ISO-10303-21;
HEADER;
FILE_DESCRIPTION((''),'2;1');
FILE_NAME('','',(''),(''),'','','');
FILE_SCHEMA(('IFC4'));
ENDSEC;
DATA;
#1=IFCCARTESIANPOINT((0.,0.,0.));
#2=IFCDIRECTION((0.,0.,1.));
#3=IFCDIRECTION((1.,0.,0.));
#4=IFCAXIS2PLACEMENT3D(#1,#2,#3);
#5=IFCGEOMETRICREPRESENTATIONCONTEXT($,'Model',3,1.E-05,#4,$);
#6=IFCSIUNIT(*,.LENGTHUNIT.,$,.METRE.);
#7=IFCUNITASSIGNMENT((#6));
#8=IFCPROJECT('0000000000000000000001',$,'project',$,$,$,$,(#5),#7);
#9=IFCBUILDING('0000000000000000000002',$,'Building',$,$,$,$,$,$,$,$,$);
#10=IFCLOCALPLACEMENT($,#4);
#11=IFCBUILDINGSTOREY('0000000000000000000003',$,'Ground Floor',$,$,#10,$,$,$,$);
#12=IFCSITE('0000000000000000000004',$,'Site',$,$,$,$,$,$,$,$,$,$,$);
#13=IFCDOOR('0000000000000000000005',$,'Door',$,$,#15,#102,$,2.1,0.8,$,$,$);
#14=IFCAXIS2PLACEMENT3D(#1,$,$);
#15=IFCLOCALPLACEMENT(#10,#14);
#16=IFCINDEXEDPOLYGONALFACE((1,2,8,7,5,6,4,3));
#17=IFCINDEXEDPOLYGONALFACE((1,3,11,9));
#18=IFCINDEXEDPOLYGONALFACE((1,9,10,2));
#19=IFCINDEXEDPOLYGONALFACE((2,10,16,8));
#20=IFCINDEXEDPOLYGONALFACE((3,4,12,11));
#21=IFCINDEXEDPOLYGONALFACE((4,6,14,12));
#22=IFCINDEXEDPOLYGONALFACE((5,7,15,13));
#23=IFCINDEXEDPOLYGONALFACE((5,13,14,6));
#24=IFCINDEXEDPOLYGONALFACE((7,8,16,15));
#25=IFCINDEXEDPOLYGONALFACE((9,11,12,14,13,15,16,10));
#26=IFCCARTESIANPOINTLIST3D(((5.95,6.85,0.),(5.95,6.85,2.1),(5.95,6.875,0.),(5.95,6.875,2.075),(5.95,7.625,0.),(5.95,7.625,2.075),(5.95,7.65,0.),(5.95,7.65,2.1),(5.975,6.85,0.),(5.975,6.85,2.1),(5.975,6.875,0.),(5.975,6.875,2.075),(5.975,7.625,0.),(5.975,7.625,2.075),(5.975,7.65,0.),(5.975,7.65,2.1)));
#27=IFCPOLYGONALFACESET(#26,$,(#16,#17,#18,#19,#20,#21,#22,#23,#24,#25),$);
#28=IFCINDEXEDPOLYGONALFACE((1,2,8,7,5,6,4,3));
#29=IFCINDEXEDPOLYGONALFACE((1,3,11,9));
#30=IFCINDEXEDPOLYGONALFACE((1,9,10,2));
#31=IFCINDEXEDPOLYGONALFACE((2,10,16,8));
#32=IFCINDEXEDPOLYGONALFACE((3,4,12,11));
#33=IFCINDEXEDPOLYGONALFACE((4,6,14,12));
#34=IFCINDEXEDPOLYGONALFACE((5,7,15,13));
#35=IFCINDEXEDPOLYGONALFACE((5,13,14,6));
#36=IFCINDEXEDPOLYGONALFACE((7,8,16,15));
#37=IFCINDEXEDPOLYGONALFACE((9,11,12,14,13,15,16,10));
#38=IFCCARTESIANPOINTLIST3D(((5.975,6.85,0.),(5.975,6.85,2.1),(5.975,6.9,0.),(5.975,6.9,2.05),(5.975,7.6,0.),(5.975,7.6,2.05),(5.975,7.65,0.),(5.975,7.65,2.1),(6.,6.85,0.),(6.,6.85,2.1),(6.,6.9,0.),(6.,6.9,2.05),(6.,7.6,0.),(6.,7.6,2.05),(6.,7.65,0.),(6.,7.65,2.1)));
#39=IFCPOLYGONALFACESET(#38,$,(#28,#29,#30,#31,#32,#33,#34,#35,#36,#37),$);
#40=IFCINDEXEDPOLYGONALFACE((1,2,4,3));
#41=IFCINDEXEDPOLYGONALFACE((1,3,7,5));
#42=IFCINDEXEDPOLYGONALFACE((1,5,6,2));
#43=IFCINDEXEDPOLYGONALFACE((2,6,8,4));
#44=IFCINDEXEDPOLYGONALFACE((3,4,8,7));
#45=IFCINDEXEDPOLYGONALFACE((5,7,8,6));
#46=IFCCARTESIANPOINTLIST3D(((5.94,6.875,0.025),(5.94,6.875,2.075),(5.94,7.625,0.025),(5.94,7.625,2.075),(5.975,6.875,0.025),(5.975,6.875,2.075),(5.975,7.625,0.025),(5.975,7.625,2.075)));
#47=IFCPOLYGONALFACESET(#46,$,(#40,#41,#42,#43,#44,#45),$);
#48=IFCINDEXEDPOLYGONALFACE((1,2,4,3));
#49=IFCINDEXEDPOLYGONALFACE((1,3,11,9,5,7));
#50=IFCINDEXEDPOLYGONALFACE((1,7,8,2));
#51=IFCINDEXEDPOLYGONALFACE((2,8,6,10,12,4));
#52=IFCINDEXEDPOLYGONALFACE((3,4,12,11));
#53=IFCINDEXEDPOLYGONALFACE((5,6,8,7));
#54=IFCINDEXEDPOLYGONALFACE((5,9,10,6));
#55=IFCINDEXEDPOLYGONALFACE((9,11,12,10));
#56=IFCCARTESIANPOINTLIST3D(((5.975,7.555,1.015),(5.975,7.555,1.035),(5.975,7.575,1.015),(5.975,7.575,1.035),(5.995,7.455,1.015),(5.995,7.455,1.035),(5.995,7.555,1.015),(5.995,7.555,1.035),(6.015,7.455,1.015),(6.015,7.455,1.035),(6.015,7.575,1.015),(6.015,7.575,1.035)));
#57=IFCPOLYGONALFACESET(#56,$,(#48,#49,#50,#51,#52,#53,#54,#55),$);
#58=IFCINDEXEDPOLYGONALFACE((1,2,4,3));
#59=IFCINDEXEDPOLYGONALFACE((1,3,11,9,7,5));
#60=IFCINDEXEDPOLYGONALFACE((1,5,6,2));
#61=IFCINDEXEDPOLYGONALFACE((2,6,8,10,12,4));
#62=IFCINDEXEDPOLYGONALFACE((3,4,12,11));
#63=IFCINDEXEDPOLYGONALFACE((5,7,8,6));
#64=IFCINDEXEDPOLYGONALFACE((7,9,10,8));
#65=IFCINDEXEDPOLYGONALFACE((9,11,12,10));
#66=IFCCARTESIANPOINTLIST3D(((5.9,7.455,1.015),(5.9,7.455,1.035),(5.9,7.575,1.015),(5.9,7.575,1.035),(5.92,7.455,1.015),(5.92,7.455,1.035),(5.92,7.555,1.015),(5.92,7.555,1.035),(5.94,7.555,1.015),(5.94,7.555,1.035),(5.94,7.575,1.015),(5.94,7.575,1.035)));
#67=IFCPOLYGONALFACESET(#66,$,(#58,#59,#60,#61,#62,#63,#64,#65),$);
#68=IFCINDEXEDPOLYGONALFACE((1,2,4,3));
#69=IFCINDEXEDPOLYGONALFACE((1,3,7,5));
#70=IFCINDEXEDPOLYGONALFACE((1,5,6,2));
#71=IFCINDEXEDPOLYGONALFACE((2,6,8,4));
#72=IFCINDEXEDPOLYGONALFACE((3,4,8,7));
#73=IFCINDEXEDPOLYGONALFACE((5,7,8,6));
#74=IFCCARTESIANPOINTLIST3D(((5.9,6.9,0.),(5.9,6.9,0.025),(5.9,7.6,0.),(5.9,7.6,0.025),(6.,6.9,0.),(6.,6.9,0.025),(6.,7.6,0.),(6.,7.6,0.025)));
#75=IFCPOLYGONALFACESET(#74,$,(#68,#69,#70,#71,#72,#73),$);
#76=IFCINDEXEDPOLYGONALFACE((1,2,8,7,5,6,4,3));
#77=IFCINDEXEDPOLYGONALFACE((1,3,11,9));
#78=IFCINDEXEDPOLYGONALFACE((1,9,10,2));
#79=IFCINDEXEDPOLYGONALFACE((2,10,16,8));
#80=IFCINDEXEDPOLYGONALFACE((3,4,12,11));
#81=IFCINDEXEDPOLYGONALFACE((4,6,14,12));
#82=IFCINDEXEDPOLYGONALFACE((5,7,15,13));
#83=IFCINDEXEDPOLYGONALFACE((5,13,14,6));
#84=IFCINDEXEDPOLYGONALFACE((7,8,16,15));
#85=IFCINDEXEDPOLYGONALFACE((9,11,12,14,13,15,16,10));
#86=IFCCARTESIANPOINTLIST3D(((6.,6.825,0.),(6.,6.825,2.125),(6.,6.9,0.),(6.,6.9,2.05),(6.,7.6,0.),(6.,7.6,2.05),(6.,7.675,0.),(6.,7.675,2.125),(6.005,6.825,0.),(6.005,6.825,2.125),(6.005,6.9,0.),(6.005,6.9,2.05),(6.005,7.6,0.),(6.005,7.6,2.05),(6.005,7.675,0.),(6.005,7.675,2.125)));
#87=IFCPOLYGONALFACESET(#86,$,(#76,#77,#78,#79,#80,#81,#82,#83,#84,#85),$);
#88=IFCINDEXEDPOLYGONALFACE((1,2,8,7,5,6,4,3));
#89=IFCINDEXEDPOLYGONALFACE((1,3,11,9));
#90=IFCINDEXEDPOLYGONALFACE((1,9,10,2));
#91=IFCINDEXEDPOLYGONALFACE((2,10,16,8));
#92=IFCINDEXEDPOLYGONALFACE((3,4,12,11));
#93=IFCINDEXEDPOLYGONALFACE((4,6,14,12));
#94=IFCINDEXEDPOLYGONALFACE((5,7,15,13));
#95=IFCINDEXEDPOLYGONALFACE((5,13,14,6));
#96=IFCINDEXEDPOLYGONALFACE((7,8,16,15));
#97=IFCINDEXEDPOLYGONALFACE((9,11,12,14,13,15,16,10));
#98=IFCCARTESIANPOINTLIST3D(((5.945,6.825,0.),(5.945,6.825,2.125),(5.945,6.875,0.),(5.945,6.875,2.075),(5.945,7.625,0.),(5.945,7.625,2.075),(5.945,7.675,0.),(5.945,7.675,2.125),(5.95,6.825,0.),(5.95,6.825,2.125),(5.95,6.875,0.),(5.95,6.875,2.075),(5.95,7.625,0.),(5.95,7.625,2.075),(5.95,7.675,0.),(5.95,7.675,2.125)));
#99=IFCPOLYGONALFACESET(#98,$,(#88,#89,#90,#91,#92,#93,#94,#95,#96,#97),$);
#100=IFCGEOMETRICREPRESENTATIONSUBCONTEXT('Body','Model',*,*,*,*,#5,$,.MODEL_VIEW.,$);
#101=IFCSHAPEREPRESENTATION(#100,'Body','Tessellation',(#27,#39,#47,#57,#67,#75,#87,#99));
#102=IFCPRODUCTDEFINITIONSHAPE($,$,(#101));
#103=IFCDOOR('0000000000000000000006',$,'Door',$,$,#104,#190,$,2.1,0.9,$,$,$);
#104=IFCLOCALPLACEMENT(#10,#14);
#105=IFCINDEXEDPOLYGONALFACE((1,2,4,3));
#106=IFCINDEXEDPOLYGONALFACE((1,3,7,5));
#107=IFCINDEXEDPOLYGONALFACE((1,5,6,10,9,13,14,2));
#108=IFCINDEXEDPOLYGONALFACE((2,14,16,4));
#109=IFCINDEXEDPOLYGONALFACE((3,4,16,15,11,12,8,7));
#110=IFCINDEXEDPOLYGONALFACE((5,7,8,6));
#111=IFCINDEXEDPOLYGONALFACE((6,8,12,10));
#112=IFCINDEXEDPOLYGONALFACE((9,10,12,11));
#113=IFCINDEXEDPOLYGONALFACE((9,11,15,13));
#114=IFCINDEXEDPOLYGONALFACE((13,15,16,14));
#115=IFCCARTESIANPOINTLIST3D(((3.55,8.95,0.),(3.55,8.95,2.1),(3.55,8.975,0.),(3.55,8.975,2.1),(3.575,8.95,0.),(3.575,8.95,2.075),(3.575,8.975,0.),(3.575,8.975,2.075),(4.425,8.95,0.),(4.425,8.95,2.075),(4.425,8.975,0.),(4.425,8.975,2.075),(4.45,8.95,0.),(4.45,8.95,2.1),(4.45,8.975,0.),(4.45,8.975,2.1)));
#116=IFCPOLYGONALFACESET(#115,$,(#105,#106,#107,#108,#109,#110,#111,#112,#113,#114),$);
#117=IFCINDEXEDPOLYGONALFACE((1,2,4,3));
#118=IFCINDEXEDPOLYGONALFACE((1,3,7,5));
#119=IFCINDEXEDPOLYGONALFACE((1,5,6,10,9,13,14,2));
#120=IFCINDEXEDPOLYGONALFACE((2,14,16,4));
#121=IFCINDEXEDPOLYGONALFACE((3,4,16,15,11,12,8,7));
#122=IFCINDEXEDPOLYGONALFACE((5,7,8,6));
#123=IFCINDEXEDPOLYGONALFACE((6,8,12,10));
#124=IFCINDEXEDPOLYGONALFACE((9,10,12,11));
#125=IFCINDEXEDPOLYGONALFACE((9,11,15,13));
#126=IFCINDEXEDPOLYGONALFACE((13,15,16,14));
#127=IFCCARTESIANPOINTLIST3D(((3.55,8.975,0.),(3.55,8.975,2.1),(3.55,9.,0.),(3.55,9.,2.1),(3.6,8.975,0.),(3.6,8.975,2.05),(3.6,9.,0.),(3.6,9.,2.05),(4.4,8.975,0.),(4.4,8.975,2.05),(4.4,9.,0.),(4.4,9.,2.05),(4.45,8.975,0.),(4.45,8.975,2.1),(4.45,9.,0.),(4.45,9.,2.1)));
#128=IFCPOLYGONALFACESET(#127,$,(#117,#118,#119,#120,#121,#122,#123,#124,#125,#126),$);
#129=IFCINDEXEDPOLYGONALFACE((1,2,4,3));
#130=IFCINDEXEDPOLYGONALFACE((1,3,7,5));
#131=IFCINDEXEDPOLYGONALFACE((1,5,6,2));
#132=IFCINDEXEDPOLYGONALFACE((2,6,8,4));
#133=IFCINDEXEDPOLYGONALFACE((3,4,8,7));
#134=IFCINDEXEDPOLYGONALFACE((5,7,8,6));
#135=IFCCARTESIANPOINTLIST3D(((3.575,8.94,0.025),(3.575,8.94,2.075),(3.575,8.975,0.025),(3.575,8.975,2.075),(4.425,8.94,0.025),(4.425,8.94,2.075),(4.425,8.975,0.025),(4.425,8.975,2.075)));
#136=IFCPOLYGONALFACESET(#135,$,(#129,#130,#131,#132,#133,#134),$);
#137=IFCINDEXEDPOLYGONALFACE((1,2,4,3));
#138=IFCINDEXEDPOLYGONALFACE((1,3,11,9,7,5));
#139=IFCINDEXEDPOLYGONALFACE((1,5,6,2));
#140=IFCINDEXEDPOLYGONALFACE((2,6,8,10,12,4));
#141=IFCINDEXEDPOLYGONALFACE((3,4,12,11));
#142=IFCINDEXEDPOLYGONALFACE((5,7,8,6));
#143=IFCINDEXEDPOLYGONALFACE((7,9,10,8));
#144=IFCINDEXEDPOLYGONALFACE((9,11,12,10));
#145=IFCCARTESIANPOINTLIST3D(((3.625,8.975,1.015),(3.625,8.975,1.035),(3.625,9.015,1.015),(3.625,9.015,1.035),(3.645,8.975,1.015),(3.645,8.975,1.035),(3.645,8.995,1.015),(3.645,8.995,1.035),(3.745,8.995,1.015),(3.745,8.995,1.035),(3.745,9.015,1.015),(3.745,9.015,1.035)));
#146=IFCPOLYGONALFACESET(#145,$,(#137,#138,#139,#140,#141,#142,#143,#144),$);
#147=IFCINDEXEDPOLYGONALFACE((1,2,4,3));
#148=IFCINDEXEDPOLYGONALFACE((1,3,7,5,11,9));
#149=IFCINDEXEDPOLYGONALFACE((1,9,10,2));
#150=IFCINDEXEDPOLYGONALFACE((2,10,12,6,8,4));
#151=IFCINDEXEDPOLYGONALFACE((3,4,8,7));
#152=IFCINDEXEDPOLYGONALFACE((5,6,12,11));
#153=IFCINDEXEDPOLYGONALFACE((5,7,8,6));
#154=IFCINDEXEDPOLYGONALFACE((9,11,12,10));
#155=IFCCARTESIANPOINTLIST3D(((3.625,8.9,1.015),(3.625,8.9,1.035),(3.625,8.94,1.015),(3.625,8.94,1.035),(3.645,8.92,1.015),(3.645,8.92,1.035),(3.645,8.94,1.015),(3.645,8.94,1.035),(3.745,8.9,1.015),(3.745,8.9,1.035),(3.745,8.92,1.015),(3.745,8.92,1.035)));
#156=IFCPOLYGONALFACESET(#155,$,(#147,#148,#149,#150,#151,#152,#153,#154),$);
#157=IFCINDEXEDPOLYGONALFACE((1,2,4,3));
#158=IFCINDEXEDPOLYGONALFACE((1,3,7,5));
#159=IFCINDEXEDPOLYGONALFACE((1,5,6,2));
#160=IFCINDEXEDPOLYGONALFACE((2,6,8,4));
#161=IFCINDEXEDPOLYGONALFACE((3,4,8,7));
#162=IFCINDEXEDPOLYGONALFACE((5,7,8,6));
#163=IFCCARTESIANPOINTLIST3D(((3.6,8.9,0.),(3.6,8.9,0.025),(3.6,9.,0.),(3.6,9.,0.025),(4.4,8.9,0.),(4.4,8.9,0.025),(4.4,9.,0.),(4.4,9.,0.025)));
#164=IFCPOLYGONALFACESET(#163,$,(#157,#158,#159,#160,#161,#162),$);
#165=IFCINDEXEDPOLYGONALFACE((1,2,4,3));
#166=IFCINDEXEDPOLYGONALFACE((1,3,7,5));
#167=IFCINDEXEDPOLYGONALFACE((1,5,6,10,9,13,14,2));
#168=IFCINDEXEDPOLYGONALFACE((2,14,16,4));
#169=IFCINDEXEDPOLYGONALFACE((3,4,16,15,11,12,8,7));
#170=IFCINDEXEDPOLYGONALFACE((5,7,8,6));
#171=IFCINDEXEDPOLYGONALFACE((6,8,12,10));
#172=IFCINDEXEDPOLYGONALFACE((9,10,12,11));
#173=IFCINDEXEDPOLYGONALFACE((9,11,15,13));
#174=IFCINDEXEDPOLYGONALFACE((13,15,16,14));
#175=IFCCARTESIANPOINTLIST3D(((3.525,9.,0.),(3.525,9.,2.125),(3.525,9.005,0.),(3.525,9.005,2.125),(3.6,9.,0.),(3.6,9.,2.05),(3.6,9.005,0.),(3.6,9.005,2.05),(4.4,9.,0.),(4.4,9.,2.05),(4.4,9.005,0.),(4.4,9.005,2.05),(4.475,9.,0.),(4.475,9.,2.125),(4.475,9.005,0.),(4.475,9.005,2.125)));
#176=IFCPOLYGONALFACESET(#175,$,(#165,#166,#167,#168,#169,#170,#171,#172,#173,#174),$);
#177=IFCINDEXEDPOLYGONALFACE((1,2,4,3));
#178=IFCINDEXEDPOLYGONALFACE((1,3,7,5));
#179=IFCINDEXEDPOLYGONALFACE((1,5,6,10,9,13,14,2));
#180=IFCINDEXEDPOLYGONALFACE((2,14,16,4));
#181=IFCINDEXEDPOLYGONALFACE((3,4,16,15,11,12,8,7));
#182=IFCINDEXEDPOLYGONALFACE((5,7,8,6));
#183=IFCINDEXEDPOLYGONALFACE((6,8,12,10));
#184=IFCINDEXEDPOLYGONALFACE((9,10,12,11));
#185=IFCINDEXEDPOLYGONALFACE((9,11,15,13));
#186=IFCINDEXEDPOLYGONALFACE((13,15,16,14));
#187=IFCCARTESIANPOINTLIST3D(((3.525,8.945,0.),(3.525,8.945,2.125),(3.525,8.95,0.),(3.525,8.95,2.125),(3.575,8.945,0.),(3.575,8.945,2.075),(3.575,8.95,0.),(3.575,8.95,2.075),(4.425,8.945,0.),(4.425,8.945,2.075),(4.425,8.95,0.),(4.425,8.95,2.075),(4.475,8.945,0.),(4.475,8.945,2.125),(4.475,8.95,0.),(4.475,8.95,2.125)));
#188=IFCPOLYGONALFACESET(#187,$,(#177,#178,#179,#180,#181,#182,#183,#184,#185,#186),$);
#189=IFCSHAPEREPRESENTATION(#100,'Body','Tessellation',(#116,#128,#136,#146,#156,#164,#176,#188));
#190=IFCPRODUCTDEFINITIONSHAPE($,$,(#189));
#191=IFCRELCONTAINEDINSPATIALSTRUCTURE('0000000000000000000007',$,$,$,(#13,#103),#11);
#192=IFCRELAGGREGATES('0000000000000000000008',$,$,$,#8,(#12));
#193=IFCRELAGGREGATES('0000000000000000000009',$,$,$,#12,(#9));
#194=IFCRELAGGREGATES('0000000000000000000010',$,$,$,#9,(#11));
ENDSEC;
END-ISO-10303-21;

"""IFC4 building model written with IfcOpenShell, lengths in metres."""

from ifc_helpers import new_model, si_unit, frame, origin_with_axes, place, context, subcontext, project, spatial, line, indexed_curve, outline, extrude, element, save


model = new_model("IFC4")

# Units and contexts
model_context = context("Model", 3, precision=1e-05, world=origin_with_axes())
body_context = subcontext(model_context, "Body", "Model", "MODEL_VIEW")
ifc_project = project(units=[si_unit("LENGTHUNIT", "METRE")], contexts=[model_context])

# Site, building, storey
site = spatial("IfcSite", under=ifc_project, Name="Site")
building = spatial("IfcBuilding", under=site, Name="Building")
storey_placement = place(None, origin_with_axes())
storey = spatial("IfcBuildingStorey", under=building, at=storey_placement, Name="Ground Floor")

# Doors
door_1_placement = place(storey_placement, frame((6.0, 6.85, 0.0), z_axis=(0.0, 0.0, 1.0), x_axis=(0.0, 1.0, 0.0)))
element("IfcDoor", 1, at=door_1_placement, inside=storey, Name="Door", OverallHeight=2.1, OverallWidth=0.8, context=body_context, shape_type="SweptSolid", body=[
    extrude(outline(indexed_curve([(0.0, 0.0), (0.0, 2.1), (0.8, 2.1), (0.8, 0.0), (0.775, 0.0), (0.775, 2.075), (0.025, 2.075), (0.025, 0.0)], segments=[line(1, 2, 3, 4, 5, 6, 7, 8, 1)])), frame((0.0, 0.025, 0.0), z_axis=(0.0, -1.0, 0.0), x_axis=(1.0, 0.0, 0.0)), (0.0, 0.0, -1.0), 0.025),
    extrude(outline(indexed_curve([(0.0, 0.0), (0.0, 2.1), (0.8, 2.1), (0.8, 0.0), (0.75, 0.0), (0.75, 2.05), (0.05, 2.05), (0.05, 0.0)], segments=[line(1, 2, 3, 4, 5, 6, 7, 8, 1)])), frame((0.0, 0.0, 0.0), z_axis=(0.0, -1.0, 0.0), x_axis=(1.0, 0.0, 0.0)), (0.0, 0.0, -1.0), 0.025),
    extrude(outline(indexed_curve([(0.0, 0.0), (0.75, 0.0), (0.75, 0.035), (0.0, 0.035)], segments=[line(1, 2, 3, 4, 1)])), frame((0.025, 0.025, 0.025), z_axis=(0.0, 0.0, 1.0), x_axis=(1.0, 0.0, 0.0)), (0.0, 0.0, 1.0), 2.05),
    extrude(outline(indexed_curve([(0.0, 0.0), (0.0, -0.04), (-0.12, -0.04), (-0.12, -0.02), (-0.02, -0.02), (-0.02, 0.0)], segments=[line(1, 2, 3, 4, 5, 6, 1)])), frame((0.725, 0.025, 1.015), z_axis=(0.0, 0.0, 1.0), x_axis=(1.0, 0.0, 0.0)), (0.0, 0.0, 1.0), 0.02),
    extrude(outline(indexed_curve([(0.0, 0.0), (0.0, 0.04), (-0.12, 0.04), (-0.12, 0.02), (-0.02, 0.02), (-0.02, 0.0)], segments=[line(1, 2, 3, 4, 5, 6, 1)])), frame((0.725, 0.06, 1.015), z_axis=(0.0, 0.0, 1.0), x_axis=(1.0, 0.0, 0.0)), (0.0, 0.0, 1.0), 0.02),
    extrude(outline(indexed_curve([(0.0, 0.0), (0.7, 0.0), (0.7, 0.1), (0.0, 0.1)], segments=[line(1, 2, 3, 4, 1)])), frame((0.05, 0.0, 0.0), z_axis=(0.0, 0.0, 1.0), x_axis=(1.0, 0.0, 0.0)), (0.0, 0.0, 1.0), 0.025),
    extrude(outline(indexed_curve([(0.0, 0.0), (0.0, 2.125), (0.85, 2.125), (0.85, 0.0), (0.775, 0.0), (0.775, 2.05), (0.075, 2.05), (0.075, 0.0)], segments=[line(1, 2, 3, 4, 5, 6, 7, 8, 1)])), frame((-0.025, -0.005, 0.0), z_axis=(0.0, -1.0, 0.0), x_axis=(1.0, 0.0, 0.0)), (0.0, 0.0, -1.0), 0.005),
    extrude(outline(indexed_curve([(0.0, 0.0), (0.0, 2.125), (0.85, 2.125), (0.85, 0.0), (0.8, 0.0), (0.8, 2.075), (0.05, 2.075), (0.05, 0.0)], segments=[line(1, 2, 3, 4, 5, 6, 7, 8, 1)])), frame((-0.025, 0.05, 0.0), z_axis=(0.0, -1.0, 0.0), x_axis=(1.0, 0.0, 0.0)), (0.0, 0.0, -1.0), 0.005),
])
door_2_placement = place(storey_placement, frame((4.45, 9.0, 0.0), z_axis=(0.0, 0.0, 1.0), x_axis=(-1.0, 0.0, 0.0)))
element("IfcDoor", 2, at=door_2_placement, inside=storey, Name="Door", OverallHeight=2.1, OverallWidth=0.9, context=body_context, shape_type="SweptSolid", body=[
    extrude(outline(indexed_curve([(0.0, 0.0), (0.0, 2.1), (0.9, 2.1), (0.9, 0.0), (0.875, 0.0), (0.875, 2.075), (0.025, 2.075), (0.025, 0.0)], segments=[line(1, 2, 3, 4, 5, 6, 7, 8, 1)])), frame((0.0, 0.025, 0.0), z_axis=(0.0, -1.0, 0.0), x_axis=(1.0, 0.0, 0.0)), (0.0, 0.0, -1.0), 0.025),
    extrude(outline(indexed_curve([(0.0, 0.0), (0.0, 2.1), (0.9, 2.1), (0.9, 0.0), (0.85, 0.0), (0.85, 2.05), (0.05, 2.05), (0.05, 0.0)], segments=[line(1, 2, 3, 4, 5, 6, 7, 8, 1)])), frame((0.0, 0.0, 0.0), z_axis=(0.0, -1.0, 0.0), x_axis=(1.0, 0.0, 0.0)), (0.0, 0.0, -1.0), 0.025),
    extrude(outline(indexed_curve([(0.0, 0.0), (0.85, 0.0), (0.85, 0.035), (0.0, 0.035)], segments=[line(1, 2, 3, 4, 1)])), frame((0.025, 0.025, 0.025), z_axis=(0.0, 0.0, 1.0), x_axis=(1.0, 0.0, 0.0)), (0.0, 0.0, 1.0), 2.05),
    extrude(outline(indexed_curve([(0.0, 0.0), (0.0, -0.04), (-0.12, -0.04), (-0.12, -0.02), (-0.02, -0.02), (-0.02, 0.0)], segments=[line(1, 2, 3, 4, 5, 6, 1)])), frame((0.825, 0.025, 1.015), z_axis=(0.0, 0.0, 1.0), x_axis=(1.0, 0.0, 0.0)), (0.0, 0.0, 1.0), 0.02),
    extrude(outline(indexed_curve([(0.0, 0.0), (0.0, 0.04), (-0.12, 0.04), (-0.12, 0.02), (-0.02, 0.02), (-0.02, 0.0)], segments=[line(1, 2, 3, 4, 5, 6, 1)])), frame((0.825, 0.06, 1.015), z_axis=(0.0, 0.0, 1.0), x_axis=(1.0, 0.0, 0.0)), (0.0, 0.0, 1.0), 0.02),
    extrude(outline(indexed_curve([(0.0, 0.0), (0.8, 0.0), (0.8, 0.1), (0.0, 0.1)], segments=[line(1, 2, 3, 4, 1)])), frame((0.05, 0.0, 0.0), z_axis=(0.0, 0.0, 1.0), x_axis=(1.0, 0.0, 0.0)), (0.0, 0.0, 1.0), 0.025),
    extrude(outline(indexed_curve([(0.0, 0.0), (0.0, 2.125), (0.95, 2.125), (0.95, 0.0), (0.875, 0.0), (0.875, 2.05), (0.075, 2.05), (0.075, 0.0)], segments=[line(1, 2, 3, 4, 5, 6, 7, 8, 1)])), frame((-0.025, -0.005, 0.0), z_axis=(0.0, -1.0, 0.0), x_axis=(1.0, 0.0, 0.0)), (0.0, 0.0, -1.0), 0.005),
    extrude(outline(indexed_curve([(0.0, 0.0), (0.0, 2.125), (0.95, 2.125), (0.95, 0.0), (0.9, 0.0), (0.9, 2.075), (0.05, 2.075), (0.05, 0.0)], segments=[line(1, 2, 3, 4, 5, 6, 7, 8, 1)])), frame((-0.025, 0.05, 0.0), z_axis=(0.0, -1.0, 0.0), x_axis=(1.0, 0.0, 0.0)), (0.0, 0.0, -1.0), 0.005),
])

save(model, "model.ifc")
